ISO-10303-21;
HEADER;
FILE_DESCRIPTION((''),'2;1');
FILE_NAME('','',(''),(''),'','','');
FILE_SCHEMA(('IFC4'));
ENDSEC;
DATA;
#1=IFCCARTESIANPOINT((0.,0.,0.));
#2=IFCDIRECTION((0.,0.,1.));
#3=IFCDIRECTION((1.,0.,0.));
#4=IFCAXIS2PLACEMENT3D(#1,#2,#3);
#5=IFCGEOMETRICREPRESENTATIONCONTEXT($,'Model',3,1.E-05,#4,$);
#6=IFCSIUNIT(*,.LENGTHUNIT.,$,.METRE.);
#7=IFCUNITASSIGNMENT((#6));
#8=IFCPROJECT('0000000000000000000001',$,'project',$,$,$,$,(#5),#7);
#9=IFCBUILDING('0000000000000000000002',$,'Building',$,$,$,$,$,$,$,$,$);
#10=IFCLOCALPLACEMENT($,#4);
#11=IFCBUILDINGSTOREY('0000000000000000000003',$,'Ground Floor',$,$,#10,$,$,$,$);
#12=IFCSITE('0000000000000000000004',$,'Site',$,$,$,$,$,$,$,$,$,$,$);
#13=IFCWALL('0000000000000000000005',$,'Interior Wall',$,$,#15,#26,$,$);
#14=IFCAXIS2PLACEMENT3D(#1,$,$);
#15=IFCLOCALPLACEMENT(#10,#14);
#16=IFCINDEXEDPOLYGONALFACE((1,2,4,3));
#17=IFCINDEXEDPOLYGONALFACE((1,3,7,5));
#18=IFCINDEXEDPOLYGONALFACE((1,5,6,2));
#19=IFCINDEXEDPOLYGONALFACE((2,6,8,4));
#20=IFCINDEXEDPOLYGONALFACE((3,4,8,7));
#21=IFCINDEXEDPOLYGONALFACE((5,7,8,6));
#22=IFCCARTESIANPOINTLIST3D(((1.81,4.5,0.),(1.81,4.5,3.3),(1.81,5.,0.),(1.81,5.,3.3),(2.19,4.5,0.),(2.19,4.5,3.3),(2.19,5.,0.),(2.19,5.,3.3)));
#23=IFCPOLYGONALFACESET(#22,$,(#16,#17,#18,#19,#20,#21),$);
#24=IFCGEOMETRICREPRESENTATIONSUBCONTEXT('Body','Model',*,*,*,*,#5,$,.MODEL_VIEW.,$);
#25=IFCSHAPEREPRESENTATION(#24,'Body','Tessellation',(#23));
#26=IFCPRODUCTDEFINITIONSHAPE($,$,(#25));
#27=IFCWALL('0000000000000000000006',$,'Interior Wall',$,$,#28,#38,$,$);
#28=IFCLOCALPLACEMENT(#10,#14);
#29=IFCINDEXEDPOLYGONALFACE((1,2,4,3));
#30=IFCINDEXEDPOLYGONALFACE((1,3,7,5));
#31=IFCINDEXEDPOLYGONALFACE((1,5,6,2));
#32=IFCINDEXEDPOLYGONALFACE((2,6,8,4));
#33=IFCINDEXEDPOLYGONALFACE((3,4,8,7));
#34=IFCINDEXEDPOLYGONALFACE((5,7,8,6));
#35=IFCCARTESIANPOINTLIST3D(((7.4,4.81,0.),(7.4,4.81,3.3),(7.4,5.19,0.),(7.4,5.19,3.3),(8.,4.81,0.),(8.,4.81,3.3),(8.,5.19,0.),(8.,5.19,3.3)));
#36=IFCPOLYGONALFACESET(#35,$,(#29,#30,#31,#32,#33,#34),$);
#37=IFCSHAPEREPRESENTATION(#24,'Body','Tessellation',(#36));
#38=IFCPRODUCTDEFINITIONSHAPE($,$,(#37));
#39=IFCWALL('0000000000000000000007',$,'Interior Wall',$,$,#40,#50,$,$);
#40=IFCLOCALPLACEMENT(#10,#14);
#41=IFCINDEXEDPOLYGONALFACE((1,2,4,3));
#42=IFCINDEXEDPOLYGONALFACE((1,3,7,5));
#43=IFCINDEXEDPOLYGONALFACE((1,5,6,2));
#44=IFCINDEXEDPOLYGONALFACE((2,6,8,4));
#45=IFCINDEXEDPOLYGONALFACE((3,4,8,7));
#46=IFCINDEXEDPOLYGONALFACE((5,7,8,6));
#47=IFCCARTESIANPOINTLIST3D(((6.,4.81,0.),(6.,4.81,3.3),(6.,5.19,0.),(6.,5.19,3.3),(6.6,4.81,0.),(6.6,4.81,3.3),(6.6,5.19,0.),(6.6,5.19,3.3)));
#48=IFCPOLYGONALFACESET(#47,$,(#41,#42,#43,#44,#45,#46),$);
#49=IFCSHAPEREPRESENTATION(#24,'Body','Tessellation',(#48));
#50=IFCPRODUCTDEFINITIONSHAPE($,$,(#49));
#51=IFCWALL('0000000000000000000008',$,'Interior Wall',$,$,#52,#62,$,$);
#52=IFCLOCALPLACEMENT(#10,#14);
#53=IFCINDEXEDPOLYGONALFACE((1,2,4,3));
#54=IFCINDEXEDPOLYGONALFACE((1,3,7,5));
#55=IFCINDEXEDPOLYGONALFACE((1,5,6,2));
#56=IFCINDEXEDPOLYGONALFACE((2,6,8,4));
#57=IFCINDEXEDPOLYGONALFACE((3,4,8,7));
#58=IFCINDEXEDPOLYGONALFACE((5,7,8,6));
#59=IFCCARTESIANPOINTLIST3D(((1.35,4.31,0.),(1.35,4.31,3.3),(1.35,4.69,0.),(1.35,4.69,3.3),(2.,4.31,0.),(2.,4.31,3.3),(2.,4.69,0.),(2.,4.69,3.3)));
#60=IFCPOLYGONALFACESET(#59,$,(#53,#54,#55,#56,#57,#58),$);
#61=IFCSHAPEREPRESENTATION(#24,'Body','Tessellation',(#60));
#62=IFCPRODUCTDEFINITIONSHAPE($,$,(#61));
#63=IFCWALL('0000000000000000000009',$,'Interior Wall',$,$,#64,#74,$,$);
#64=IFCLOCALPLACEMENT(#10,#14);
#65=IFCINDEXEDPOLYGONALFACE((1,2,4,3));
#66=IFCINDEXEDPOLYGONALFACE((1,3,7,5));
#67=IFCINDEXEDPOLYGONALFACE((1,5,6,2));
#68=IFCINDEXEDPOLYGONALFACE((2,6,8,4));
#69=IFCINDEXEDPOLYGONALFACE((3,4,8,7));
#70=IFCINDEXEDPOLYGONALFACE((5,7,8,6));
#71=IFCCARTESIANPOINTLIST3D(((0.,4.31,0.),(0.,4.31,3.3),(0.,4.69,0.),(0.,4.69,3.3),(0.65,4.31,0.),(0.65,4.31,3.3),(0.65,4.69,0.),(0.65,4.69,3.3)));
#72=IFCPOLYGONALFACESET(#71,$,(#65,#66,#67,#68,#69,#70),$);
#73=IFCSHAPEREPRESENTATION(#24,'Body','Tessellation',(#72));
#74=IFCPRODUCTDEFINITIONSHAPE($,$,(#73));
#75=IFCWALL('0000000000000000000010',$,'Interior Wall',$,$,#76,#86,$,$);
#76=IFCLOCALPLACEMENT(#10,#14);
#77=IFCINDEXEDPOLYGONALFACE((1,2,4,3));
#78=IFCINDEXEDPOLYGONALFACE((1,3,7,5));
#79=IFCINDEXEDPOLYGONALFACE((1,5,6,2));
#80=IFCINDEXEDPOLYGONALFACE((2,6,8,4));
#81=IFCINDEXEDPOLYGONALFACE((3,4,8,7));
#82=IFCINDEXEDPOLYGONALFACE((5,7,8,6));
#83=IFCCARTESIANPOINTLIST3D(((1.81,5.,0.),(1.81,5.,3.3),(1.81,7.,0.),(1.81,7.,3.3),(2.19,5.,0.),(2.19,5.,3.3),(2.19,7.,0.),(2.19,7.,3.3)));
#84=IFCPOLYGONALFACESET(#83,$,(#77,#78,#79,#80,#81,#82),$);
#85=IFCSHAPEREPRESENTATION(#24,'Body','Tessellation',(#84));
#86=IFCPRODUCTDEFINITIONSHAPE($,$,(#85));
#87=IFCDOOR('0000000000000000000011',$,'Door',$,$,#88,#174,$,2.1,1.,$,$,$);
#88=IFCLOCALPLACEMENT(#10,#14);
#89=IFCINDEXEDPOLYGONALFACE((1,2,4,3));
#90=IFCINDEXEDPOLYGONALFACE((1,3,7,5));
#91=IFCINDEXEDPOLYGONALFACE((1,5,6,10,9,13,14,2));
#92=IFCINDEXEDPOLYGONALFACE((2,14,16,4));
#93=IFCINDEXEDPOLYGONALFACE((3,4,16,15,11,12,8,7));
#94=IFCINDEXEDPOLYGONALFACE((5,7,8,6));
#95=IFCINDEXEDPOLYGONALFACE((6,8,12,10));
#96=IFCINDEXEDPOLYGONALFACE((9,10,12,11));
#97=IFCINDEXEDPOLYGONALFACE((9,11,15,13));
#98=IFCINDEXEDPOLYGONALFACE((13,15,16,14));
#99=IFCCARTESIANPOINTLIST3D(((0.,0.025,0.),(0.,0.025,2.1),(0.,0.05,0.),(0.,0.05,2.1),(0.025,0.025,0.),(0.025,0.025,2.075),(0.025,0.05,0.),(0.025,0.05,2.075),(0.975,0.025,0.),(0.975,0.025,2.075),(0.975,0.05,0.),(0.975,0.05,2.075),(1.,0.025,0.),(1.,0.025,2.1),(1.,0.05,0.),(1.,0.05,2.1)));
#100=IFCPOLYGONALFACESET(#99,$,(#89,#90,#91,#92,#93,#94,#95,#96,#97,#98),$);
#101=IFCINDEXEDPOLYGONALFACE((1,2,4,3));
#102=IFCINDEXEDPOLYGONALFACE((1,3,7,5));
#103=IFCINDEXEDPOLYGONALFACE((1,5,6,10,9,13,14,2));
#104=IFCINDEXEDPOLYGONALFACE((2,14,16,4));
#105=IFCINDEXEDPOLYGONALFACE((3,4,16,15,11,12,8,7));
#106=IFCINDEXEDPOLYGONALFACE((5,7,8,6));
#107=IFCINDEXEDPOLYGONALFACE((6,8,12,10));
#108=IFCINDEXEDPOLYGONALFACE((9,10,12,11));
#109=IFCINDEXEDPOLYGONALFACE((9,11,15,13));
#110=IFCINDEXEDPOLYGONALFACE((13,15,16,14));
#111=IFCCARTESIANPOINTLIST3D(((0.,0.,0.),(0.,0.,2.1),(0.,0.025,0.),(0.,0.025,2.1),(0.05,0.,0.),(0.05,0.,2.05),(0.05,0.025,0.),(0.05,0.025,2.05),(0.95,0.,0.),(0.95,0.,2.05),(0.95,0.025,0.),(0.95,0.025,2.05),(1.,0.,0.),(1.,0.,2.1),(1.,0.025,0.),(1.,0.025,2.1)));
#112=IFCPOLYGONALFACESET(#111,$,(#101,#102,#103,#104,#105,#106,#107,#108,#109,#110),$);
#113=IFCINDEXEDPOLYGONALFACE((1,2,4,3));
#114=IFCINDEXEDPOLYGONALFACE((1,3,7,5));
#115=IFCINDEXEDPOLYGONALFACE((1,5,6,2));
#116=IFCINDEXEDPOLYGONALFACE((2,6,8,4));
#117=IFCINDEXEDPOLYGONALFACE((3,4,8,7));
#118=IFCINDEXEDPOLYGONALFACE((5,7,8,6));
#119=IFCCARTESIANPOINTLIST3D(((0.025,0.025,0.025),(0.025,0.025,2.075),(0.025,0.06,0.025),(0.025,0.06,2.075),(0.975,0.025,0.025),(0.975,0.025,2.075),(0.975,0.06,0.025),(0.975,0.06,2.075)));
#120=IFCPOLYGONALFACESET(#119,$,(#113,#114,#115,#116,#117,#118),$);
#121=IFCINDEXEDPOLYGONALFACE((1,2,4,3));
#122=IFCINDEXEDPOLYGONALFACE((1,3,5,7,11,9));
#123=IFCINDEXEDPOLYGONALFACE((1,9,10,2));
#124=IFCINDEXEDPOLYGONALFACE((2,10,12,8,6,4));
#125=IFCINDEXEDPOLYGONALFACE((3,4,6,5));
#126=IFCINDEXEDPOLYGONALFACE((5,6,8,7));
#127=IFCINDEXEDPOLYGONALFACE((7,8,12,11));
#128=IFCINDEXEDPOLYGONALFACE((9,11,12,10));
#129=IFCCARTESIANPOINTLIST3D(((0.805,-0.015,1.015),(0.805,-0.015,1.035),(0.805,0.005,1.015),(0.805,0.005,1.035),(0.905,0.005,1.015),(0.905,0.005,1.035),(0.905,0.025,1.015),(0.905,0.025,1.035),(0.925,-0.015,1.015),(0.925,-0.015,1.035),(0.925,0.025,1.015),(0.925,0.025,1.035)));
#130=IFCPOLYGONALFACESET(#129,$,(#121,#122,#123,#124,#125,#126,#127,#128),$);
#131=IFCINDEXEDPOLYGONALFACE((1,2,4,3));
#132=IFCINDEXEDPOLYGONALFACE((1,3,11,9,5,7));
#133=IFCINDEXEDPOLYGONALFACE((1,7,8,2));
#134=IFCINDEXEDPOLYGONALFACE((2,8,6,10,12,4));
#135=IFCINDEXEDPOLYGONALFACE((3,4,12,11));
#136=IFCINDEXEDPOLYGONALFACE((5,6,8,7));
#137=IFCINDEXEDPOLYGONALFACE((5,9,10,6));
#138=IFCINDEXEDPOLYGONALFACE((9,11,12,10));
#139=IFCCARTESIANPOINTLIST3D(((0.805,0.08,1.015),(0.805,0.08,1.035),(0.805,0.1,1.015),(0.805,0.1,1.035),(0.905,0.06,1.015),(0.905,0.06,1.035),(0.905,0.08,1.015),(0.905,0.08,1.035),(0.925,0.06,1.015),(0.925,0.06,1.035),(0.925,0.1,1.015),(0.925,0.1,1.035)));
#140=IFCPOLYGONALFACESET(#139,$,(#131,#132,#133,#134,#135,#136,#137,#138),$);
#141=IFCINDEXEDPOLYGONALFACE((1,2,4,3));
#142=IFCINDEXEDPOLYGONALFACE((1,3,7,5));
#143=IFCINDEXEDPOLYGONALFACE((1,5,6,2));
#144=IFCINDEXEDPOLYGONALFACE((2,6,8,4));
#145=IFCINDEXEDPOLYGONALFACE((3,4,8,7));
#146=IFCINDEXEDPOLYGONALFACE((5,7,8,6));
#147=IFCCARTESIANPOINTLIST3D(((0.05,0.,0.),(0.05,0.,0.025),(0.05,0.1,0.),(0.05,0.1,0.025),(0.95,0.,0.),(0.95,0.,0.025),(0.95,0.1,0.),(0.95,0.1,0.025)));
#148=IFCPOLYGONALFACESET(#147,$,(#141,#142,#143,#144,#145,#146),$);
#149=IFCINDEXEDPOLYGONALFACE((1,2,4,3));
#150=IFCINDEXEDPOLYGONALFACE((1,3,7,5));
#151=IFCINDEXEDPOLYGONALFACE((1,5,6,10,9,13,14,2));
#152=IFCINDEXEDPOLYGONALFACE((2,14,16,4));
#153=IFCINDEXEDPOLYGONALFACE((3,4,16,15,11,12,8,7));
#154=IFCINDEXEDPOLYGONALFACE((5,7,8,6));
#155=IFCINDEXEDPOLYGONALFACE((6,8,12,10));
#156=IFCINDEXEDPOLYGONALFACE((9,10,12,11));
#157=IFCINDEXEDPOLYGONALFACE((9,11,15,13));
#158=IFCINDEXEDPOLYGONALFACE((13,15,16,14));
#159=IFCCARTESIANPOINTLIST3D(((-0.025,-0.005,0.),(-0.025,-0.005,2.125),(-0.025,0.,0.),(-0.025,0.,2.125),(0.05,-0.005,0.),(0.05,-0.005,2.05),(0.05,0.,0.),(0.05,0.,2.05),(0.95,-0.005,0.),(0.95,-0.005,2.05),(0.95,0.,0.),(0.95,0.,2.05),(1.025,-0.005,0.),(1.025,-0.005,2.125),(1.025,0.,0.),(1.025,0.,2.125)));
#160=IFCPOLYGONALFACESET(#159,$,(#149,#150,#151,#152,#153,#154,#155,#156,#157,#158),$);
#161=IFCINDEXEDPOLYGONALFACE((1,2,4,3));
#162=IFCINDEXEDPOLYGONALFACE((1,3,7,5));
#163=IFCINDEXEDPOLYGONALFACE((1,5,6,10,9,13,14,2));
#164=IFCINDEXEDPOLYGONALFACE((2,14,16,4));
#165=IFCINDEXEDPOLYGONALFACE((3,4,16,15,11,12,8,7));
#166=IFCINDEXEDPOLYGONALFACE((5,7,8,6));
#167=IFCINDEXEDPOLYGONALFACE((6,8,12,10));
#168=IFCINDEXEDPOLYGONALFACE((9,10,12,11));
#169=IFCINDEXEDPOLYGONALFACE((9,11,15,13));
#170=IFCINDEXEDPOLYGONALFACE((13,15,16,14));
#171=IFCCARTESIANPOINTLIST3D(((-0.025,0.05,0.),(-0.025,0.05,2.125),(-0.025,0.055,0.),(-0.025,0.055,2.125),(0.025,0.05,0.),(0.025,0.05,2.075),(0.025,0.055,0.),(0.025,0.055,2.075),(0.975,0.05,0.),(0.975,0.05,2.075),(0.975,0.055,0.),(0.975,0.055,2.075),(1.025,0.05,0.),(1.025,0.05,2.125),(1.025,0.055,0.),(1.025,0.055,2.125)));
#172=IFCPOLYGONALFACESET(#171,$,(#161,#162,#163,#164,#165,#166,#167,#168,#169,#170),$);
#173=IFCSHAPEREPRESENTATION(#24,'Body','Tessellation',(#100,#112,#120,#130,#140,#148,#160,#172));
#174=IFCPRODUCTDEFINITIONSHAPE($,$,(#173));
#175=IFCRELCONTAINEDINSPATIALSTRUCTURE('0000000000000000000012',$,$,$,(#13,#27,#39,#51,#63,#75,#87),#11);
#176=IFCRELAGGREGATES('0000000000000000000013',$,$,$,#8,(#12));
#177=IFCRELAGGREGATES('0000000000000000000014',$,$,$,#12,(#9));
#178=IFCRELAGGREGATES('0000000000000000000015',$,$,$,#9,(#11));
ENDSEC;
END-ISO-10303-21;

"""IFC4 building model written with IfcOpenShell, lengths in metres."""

from ifc_helpers import new_model, si_unit, frame, origin_with_axes, place, context, subcontext, project, spatial, line, indexed_curve, outline, extrude, element, save


model = new_model("IFC4")

# Units and contexts
model_context = context("Model", 3, precision=1e-05, world=origin_with_axes())
body_context = subcontext(model_context, "Body", "Model", "MODEL_VIEW")
ifc_project = project(units=[si_unit("LENGTHUNIT", "METRE")], contexts=[model_context])

# Site, building, storey
site = spatial("IfcSite", under=ifc_project, Name="Site")
building = spatial("IfcBuilding", under=site, Name="Building")
storey_placement = place(None, origin_with_axes())
storey = spatial("IfcBuildingStorey", under=building, at=storey_placement, Name="Ground Floor")

# Walls
wall_1_placement = place(storey_placement, frame((2.0, 5.0, 0.0), z_axis=(0.0, 0.0, 1.0), x_axis=(0.0, -1.0, 0.0)))
element("IfcWall", 1, at=wall_1_placement, inside=storey, Name="Interior Wall", context=body_context, shape_type="SweptSolid", body=[
    extrude(outline(indexed_curve([(0.0, 0.0), (0.0, 0.38), (0.5, 0.38), (0.5, 0.0), (0.0, 0.0)], self_intersect=False)), frame((0.0, -0.19, 0.0), z_axis=(0.0, 0.0, 1.0), x_axis=(1.0, 0.0, 0.0)), (0.0, 0.0, 1.0), 3.3),
])
for number, where, z_axis, x_axis, name in (
    (2, (8.0, 5.0, 0.0), (0.0, 0.0, 1.0), (-1.0, 0.0, 0.0), "Interior Wall"),
    (3, (6.6, 5.0, 0.0), (0.0, 0.0, 1.0), (-1.0, 0.0, 0.0), "Interior Wall"),
):
    element("IfcWall", number, at=place(storey_placement, frame(where, z_axis=z_axis, x_axis=x_axis)), inside=storey, Name=name, context=body_context, shape_type="SweptSolid", body=[
        extrude(outline(indexed_curve([(0.0, 0.0), (0.0, 0.38), (0.6, 0.38), (0.6, 0.0), (0.0, 0.0)], self_intersect=False)), frame((0.0, -0.19, 0.0), z_axis=(0.0, 0.0, 1.0), x_axis=(1.0, 0.0, 0.0)), (0.0, 0.0, 1.0), 3.3),
    ])
for number, where, z_axis, x_axis, name in (
    (4, (2.0, 4.5, 0.0), (0.0, 0.0, 1.0), (-1.0, 0.0, 0.0), "Interior Wall"),
    (5, (0.65, 4.5, 0.0), (0.0, 0.0, 1.0), (-1.0, 0.0, 0.0), "Interior Wall"),
):
    element("IfcWall", number, at=place(storey_placement, frame(where, z_axis=z_axis, x_axis=x_axis)), inside=storey, Name=name, context=body_context, shape_type="SweptSolid", body=[
        extrude(outline(indexed_curve([(0.0, 0.0), (0.0, 0.38), (0.65, 0.38), (0.65, 0.0), (0.0, 0.0)], self_intersect=False)), frame((0.0, -0.19, 0.0), z_axis=(0.0, 0.0, 1.0), x_axis=(1.0, 0.0, 0.0)), (0.0, 0.0, 1.0), 3.3),
    ])
wall_2_placement = place(storey_placement, frame((2.0, 5.0, 0.0), z_axis=(0.0, 0.0, 1.0), x_axis=(0.0, 1.0, 0.0)))
element("IfcWall", 6, at=wall_2_placement, inside=storey, Name="Interior Wall", context=body_context, shape_type="SweptSolid", body=[
    extrude(outline(indexed_curve([(0.0, 0.0), (0.0, 0.38), (2.0, 0.38), (2.0, 0.0), (0.0, 0.0)], self_intersect=False)), frame((0.0, -0.19, 0.0), z_axis=(0.0, 0.0, 1.0), x_axis=(1.0, 0.0, 0.0)), (0.0, 0.0, 1.0), 3.3),
])

# Door
door_1_placement = place(storey_placement, origin_with_axes())
element("IfcDoor", 7, at=door_1_placement, inside=storey, Name="Door", OverallHeight=2.1, OverallWidth=1.0, context=body_context, shape_type="SweptSolid", body=[
    extrude(outline(indexed_curve([(0.0, 0.0), (0.0, 2.1), (1.0, 2.1), (1.0, 0.0), (0.975, 0.0), (0.975, 2.075), (0.025, 2.075), (0.025, 0.0)], segments=[line(1, 2, 3, 4, 5, 6, 7, 8, 1)])), frame((0.0, 0.025, 0.0), z_axis=(0.0, -1.0, 0.0), x_axis=(1.0, 0.0, 0.0)), (0.0, 0.0, -1.0), 0.025),
    extrude(outline(indexed_curve([(0.0, 0.0), (0.0, 2.1), (1.0, 2.1), (1.0, 0.0), (0.95, 0.0), (0.95, 2.05), (0.05, 2.05), (0.05, 0.0)], segments=[line(1, 2, 3, 4, 5, 6, 7, 8, 1)])), frame((0.0, 0.0, 0.0), z_axis=(0.0, -1.0, 0.0), x_axis=(1.0, 0.0, 0.0)), (0.0, 0.0, -1.0), 0.025),
    extrude(outline(indexed_curve([(0.0, 0.0), (0.95, 0.0), (0.95, 0.035), (0.0, 0.035)], segments=[line(1, 2, 3, 4, 1)])), frame((0.025, 0.025, 0.025), z_axis=(0.0, 0.0, 1.0), x_axis=(1.0, 0.0, 0.0)), (0.0, 0.0, 1.0), 2.05),
    extrude(outline(indexed_curve([(0.0, 0.0), (0.0, -0.04), (-0.12, -0.04), (-0.12, -0.02), (-0.02, -0.02), (-0.02, 0.0)], segments=[line(1, 2, 3, 4, 5, 6, 1)])), frame((0.925, 0.025, 1.015), z_axis=(0.0, 0.0, 1.0), x_axis=(1.0, 0.0, 0.0)), (0.0, 0.0, 1.0), 0.02),
    extrude(outline(indexed_curve([(0.0, 0.0), (0.0, 0.04), (-0.12, 0.04), (-0.12, 0.02), (-0.02, 0.02), (-0.02, 0.0)], segments=[line(1, 2, 3, 4, 5, 6, 1)])), frame((0.925, 0.06, 1.015), z_axis=(0.0, 0.0, 1.0), x_axis=(1.0, 0.0, 0.0)), (0.0, 0.0, 1.0), 0.02),
    extrude(outline(indexed_curve([(0.0, 0.0), (0.9, 0.0), (0.9, 0.1), (0.0, 0.1)], segments=[line(1, 2, 3, 4, 1)])), frame((0.05, 0.0, 0.0), z_axis=(0.0, 0.0, 1.0), x_axis=(1.0, 0.0, 0.0)), (0.0, 0.0, 1.0), 0.025),
    extrude(outline(indexed_curve([(0.0, 0.0), (0.0, 2.125), (1.05, 2.125), (1.05, 0.0), (0.975, 0.0), (0.975, 2.05), (0.075, 2.05), (0.075, 0.0)], segments=[line(1, 2, 3, 4, 5, 6, 7, 8, 1)])), frame((-0.025, -0.005, 0.0), z_axis=(0.0, -1.0, 0.0), x_axis=(1.0, 0.0, 0.0)), (0.0, 0.0, -1.0), 0.005),
    extrude(outline(indexed_curve([(0.0, 0.0), (0.0, 2.125), (1.05, 2.125), (1.05, 0.0), (1.0, 0.0), (1.0, 2.075), (0.05, 2.075), (0.05, 0.0)], segments=[line(1, 2, 3, 4, 5, 6, 7, 8, 1)])), frame((-0.025, 0.05, 0.0), z_axis=(0.0, -1.0, 0.0), x_axis=(1.0, 0.0, 0.0)), (0.0, 0.0, -1.0), 0.005),
])

save(model, "model.ifc")
